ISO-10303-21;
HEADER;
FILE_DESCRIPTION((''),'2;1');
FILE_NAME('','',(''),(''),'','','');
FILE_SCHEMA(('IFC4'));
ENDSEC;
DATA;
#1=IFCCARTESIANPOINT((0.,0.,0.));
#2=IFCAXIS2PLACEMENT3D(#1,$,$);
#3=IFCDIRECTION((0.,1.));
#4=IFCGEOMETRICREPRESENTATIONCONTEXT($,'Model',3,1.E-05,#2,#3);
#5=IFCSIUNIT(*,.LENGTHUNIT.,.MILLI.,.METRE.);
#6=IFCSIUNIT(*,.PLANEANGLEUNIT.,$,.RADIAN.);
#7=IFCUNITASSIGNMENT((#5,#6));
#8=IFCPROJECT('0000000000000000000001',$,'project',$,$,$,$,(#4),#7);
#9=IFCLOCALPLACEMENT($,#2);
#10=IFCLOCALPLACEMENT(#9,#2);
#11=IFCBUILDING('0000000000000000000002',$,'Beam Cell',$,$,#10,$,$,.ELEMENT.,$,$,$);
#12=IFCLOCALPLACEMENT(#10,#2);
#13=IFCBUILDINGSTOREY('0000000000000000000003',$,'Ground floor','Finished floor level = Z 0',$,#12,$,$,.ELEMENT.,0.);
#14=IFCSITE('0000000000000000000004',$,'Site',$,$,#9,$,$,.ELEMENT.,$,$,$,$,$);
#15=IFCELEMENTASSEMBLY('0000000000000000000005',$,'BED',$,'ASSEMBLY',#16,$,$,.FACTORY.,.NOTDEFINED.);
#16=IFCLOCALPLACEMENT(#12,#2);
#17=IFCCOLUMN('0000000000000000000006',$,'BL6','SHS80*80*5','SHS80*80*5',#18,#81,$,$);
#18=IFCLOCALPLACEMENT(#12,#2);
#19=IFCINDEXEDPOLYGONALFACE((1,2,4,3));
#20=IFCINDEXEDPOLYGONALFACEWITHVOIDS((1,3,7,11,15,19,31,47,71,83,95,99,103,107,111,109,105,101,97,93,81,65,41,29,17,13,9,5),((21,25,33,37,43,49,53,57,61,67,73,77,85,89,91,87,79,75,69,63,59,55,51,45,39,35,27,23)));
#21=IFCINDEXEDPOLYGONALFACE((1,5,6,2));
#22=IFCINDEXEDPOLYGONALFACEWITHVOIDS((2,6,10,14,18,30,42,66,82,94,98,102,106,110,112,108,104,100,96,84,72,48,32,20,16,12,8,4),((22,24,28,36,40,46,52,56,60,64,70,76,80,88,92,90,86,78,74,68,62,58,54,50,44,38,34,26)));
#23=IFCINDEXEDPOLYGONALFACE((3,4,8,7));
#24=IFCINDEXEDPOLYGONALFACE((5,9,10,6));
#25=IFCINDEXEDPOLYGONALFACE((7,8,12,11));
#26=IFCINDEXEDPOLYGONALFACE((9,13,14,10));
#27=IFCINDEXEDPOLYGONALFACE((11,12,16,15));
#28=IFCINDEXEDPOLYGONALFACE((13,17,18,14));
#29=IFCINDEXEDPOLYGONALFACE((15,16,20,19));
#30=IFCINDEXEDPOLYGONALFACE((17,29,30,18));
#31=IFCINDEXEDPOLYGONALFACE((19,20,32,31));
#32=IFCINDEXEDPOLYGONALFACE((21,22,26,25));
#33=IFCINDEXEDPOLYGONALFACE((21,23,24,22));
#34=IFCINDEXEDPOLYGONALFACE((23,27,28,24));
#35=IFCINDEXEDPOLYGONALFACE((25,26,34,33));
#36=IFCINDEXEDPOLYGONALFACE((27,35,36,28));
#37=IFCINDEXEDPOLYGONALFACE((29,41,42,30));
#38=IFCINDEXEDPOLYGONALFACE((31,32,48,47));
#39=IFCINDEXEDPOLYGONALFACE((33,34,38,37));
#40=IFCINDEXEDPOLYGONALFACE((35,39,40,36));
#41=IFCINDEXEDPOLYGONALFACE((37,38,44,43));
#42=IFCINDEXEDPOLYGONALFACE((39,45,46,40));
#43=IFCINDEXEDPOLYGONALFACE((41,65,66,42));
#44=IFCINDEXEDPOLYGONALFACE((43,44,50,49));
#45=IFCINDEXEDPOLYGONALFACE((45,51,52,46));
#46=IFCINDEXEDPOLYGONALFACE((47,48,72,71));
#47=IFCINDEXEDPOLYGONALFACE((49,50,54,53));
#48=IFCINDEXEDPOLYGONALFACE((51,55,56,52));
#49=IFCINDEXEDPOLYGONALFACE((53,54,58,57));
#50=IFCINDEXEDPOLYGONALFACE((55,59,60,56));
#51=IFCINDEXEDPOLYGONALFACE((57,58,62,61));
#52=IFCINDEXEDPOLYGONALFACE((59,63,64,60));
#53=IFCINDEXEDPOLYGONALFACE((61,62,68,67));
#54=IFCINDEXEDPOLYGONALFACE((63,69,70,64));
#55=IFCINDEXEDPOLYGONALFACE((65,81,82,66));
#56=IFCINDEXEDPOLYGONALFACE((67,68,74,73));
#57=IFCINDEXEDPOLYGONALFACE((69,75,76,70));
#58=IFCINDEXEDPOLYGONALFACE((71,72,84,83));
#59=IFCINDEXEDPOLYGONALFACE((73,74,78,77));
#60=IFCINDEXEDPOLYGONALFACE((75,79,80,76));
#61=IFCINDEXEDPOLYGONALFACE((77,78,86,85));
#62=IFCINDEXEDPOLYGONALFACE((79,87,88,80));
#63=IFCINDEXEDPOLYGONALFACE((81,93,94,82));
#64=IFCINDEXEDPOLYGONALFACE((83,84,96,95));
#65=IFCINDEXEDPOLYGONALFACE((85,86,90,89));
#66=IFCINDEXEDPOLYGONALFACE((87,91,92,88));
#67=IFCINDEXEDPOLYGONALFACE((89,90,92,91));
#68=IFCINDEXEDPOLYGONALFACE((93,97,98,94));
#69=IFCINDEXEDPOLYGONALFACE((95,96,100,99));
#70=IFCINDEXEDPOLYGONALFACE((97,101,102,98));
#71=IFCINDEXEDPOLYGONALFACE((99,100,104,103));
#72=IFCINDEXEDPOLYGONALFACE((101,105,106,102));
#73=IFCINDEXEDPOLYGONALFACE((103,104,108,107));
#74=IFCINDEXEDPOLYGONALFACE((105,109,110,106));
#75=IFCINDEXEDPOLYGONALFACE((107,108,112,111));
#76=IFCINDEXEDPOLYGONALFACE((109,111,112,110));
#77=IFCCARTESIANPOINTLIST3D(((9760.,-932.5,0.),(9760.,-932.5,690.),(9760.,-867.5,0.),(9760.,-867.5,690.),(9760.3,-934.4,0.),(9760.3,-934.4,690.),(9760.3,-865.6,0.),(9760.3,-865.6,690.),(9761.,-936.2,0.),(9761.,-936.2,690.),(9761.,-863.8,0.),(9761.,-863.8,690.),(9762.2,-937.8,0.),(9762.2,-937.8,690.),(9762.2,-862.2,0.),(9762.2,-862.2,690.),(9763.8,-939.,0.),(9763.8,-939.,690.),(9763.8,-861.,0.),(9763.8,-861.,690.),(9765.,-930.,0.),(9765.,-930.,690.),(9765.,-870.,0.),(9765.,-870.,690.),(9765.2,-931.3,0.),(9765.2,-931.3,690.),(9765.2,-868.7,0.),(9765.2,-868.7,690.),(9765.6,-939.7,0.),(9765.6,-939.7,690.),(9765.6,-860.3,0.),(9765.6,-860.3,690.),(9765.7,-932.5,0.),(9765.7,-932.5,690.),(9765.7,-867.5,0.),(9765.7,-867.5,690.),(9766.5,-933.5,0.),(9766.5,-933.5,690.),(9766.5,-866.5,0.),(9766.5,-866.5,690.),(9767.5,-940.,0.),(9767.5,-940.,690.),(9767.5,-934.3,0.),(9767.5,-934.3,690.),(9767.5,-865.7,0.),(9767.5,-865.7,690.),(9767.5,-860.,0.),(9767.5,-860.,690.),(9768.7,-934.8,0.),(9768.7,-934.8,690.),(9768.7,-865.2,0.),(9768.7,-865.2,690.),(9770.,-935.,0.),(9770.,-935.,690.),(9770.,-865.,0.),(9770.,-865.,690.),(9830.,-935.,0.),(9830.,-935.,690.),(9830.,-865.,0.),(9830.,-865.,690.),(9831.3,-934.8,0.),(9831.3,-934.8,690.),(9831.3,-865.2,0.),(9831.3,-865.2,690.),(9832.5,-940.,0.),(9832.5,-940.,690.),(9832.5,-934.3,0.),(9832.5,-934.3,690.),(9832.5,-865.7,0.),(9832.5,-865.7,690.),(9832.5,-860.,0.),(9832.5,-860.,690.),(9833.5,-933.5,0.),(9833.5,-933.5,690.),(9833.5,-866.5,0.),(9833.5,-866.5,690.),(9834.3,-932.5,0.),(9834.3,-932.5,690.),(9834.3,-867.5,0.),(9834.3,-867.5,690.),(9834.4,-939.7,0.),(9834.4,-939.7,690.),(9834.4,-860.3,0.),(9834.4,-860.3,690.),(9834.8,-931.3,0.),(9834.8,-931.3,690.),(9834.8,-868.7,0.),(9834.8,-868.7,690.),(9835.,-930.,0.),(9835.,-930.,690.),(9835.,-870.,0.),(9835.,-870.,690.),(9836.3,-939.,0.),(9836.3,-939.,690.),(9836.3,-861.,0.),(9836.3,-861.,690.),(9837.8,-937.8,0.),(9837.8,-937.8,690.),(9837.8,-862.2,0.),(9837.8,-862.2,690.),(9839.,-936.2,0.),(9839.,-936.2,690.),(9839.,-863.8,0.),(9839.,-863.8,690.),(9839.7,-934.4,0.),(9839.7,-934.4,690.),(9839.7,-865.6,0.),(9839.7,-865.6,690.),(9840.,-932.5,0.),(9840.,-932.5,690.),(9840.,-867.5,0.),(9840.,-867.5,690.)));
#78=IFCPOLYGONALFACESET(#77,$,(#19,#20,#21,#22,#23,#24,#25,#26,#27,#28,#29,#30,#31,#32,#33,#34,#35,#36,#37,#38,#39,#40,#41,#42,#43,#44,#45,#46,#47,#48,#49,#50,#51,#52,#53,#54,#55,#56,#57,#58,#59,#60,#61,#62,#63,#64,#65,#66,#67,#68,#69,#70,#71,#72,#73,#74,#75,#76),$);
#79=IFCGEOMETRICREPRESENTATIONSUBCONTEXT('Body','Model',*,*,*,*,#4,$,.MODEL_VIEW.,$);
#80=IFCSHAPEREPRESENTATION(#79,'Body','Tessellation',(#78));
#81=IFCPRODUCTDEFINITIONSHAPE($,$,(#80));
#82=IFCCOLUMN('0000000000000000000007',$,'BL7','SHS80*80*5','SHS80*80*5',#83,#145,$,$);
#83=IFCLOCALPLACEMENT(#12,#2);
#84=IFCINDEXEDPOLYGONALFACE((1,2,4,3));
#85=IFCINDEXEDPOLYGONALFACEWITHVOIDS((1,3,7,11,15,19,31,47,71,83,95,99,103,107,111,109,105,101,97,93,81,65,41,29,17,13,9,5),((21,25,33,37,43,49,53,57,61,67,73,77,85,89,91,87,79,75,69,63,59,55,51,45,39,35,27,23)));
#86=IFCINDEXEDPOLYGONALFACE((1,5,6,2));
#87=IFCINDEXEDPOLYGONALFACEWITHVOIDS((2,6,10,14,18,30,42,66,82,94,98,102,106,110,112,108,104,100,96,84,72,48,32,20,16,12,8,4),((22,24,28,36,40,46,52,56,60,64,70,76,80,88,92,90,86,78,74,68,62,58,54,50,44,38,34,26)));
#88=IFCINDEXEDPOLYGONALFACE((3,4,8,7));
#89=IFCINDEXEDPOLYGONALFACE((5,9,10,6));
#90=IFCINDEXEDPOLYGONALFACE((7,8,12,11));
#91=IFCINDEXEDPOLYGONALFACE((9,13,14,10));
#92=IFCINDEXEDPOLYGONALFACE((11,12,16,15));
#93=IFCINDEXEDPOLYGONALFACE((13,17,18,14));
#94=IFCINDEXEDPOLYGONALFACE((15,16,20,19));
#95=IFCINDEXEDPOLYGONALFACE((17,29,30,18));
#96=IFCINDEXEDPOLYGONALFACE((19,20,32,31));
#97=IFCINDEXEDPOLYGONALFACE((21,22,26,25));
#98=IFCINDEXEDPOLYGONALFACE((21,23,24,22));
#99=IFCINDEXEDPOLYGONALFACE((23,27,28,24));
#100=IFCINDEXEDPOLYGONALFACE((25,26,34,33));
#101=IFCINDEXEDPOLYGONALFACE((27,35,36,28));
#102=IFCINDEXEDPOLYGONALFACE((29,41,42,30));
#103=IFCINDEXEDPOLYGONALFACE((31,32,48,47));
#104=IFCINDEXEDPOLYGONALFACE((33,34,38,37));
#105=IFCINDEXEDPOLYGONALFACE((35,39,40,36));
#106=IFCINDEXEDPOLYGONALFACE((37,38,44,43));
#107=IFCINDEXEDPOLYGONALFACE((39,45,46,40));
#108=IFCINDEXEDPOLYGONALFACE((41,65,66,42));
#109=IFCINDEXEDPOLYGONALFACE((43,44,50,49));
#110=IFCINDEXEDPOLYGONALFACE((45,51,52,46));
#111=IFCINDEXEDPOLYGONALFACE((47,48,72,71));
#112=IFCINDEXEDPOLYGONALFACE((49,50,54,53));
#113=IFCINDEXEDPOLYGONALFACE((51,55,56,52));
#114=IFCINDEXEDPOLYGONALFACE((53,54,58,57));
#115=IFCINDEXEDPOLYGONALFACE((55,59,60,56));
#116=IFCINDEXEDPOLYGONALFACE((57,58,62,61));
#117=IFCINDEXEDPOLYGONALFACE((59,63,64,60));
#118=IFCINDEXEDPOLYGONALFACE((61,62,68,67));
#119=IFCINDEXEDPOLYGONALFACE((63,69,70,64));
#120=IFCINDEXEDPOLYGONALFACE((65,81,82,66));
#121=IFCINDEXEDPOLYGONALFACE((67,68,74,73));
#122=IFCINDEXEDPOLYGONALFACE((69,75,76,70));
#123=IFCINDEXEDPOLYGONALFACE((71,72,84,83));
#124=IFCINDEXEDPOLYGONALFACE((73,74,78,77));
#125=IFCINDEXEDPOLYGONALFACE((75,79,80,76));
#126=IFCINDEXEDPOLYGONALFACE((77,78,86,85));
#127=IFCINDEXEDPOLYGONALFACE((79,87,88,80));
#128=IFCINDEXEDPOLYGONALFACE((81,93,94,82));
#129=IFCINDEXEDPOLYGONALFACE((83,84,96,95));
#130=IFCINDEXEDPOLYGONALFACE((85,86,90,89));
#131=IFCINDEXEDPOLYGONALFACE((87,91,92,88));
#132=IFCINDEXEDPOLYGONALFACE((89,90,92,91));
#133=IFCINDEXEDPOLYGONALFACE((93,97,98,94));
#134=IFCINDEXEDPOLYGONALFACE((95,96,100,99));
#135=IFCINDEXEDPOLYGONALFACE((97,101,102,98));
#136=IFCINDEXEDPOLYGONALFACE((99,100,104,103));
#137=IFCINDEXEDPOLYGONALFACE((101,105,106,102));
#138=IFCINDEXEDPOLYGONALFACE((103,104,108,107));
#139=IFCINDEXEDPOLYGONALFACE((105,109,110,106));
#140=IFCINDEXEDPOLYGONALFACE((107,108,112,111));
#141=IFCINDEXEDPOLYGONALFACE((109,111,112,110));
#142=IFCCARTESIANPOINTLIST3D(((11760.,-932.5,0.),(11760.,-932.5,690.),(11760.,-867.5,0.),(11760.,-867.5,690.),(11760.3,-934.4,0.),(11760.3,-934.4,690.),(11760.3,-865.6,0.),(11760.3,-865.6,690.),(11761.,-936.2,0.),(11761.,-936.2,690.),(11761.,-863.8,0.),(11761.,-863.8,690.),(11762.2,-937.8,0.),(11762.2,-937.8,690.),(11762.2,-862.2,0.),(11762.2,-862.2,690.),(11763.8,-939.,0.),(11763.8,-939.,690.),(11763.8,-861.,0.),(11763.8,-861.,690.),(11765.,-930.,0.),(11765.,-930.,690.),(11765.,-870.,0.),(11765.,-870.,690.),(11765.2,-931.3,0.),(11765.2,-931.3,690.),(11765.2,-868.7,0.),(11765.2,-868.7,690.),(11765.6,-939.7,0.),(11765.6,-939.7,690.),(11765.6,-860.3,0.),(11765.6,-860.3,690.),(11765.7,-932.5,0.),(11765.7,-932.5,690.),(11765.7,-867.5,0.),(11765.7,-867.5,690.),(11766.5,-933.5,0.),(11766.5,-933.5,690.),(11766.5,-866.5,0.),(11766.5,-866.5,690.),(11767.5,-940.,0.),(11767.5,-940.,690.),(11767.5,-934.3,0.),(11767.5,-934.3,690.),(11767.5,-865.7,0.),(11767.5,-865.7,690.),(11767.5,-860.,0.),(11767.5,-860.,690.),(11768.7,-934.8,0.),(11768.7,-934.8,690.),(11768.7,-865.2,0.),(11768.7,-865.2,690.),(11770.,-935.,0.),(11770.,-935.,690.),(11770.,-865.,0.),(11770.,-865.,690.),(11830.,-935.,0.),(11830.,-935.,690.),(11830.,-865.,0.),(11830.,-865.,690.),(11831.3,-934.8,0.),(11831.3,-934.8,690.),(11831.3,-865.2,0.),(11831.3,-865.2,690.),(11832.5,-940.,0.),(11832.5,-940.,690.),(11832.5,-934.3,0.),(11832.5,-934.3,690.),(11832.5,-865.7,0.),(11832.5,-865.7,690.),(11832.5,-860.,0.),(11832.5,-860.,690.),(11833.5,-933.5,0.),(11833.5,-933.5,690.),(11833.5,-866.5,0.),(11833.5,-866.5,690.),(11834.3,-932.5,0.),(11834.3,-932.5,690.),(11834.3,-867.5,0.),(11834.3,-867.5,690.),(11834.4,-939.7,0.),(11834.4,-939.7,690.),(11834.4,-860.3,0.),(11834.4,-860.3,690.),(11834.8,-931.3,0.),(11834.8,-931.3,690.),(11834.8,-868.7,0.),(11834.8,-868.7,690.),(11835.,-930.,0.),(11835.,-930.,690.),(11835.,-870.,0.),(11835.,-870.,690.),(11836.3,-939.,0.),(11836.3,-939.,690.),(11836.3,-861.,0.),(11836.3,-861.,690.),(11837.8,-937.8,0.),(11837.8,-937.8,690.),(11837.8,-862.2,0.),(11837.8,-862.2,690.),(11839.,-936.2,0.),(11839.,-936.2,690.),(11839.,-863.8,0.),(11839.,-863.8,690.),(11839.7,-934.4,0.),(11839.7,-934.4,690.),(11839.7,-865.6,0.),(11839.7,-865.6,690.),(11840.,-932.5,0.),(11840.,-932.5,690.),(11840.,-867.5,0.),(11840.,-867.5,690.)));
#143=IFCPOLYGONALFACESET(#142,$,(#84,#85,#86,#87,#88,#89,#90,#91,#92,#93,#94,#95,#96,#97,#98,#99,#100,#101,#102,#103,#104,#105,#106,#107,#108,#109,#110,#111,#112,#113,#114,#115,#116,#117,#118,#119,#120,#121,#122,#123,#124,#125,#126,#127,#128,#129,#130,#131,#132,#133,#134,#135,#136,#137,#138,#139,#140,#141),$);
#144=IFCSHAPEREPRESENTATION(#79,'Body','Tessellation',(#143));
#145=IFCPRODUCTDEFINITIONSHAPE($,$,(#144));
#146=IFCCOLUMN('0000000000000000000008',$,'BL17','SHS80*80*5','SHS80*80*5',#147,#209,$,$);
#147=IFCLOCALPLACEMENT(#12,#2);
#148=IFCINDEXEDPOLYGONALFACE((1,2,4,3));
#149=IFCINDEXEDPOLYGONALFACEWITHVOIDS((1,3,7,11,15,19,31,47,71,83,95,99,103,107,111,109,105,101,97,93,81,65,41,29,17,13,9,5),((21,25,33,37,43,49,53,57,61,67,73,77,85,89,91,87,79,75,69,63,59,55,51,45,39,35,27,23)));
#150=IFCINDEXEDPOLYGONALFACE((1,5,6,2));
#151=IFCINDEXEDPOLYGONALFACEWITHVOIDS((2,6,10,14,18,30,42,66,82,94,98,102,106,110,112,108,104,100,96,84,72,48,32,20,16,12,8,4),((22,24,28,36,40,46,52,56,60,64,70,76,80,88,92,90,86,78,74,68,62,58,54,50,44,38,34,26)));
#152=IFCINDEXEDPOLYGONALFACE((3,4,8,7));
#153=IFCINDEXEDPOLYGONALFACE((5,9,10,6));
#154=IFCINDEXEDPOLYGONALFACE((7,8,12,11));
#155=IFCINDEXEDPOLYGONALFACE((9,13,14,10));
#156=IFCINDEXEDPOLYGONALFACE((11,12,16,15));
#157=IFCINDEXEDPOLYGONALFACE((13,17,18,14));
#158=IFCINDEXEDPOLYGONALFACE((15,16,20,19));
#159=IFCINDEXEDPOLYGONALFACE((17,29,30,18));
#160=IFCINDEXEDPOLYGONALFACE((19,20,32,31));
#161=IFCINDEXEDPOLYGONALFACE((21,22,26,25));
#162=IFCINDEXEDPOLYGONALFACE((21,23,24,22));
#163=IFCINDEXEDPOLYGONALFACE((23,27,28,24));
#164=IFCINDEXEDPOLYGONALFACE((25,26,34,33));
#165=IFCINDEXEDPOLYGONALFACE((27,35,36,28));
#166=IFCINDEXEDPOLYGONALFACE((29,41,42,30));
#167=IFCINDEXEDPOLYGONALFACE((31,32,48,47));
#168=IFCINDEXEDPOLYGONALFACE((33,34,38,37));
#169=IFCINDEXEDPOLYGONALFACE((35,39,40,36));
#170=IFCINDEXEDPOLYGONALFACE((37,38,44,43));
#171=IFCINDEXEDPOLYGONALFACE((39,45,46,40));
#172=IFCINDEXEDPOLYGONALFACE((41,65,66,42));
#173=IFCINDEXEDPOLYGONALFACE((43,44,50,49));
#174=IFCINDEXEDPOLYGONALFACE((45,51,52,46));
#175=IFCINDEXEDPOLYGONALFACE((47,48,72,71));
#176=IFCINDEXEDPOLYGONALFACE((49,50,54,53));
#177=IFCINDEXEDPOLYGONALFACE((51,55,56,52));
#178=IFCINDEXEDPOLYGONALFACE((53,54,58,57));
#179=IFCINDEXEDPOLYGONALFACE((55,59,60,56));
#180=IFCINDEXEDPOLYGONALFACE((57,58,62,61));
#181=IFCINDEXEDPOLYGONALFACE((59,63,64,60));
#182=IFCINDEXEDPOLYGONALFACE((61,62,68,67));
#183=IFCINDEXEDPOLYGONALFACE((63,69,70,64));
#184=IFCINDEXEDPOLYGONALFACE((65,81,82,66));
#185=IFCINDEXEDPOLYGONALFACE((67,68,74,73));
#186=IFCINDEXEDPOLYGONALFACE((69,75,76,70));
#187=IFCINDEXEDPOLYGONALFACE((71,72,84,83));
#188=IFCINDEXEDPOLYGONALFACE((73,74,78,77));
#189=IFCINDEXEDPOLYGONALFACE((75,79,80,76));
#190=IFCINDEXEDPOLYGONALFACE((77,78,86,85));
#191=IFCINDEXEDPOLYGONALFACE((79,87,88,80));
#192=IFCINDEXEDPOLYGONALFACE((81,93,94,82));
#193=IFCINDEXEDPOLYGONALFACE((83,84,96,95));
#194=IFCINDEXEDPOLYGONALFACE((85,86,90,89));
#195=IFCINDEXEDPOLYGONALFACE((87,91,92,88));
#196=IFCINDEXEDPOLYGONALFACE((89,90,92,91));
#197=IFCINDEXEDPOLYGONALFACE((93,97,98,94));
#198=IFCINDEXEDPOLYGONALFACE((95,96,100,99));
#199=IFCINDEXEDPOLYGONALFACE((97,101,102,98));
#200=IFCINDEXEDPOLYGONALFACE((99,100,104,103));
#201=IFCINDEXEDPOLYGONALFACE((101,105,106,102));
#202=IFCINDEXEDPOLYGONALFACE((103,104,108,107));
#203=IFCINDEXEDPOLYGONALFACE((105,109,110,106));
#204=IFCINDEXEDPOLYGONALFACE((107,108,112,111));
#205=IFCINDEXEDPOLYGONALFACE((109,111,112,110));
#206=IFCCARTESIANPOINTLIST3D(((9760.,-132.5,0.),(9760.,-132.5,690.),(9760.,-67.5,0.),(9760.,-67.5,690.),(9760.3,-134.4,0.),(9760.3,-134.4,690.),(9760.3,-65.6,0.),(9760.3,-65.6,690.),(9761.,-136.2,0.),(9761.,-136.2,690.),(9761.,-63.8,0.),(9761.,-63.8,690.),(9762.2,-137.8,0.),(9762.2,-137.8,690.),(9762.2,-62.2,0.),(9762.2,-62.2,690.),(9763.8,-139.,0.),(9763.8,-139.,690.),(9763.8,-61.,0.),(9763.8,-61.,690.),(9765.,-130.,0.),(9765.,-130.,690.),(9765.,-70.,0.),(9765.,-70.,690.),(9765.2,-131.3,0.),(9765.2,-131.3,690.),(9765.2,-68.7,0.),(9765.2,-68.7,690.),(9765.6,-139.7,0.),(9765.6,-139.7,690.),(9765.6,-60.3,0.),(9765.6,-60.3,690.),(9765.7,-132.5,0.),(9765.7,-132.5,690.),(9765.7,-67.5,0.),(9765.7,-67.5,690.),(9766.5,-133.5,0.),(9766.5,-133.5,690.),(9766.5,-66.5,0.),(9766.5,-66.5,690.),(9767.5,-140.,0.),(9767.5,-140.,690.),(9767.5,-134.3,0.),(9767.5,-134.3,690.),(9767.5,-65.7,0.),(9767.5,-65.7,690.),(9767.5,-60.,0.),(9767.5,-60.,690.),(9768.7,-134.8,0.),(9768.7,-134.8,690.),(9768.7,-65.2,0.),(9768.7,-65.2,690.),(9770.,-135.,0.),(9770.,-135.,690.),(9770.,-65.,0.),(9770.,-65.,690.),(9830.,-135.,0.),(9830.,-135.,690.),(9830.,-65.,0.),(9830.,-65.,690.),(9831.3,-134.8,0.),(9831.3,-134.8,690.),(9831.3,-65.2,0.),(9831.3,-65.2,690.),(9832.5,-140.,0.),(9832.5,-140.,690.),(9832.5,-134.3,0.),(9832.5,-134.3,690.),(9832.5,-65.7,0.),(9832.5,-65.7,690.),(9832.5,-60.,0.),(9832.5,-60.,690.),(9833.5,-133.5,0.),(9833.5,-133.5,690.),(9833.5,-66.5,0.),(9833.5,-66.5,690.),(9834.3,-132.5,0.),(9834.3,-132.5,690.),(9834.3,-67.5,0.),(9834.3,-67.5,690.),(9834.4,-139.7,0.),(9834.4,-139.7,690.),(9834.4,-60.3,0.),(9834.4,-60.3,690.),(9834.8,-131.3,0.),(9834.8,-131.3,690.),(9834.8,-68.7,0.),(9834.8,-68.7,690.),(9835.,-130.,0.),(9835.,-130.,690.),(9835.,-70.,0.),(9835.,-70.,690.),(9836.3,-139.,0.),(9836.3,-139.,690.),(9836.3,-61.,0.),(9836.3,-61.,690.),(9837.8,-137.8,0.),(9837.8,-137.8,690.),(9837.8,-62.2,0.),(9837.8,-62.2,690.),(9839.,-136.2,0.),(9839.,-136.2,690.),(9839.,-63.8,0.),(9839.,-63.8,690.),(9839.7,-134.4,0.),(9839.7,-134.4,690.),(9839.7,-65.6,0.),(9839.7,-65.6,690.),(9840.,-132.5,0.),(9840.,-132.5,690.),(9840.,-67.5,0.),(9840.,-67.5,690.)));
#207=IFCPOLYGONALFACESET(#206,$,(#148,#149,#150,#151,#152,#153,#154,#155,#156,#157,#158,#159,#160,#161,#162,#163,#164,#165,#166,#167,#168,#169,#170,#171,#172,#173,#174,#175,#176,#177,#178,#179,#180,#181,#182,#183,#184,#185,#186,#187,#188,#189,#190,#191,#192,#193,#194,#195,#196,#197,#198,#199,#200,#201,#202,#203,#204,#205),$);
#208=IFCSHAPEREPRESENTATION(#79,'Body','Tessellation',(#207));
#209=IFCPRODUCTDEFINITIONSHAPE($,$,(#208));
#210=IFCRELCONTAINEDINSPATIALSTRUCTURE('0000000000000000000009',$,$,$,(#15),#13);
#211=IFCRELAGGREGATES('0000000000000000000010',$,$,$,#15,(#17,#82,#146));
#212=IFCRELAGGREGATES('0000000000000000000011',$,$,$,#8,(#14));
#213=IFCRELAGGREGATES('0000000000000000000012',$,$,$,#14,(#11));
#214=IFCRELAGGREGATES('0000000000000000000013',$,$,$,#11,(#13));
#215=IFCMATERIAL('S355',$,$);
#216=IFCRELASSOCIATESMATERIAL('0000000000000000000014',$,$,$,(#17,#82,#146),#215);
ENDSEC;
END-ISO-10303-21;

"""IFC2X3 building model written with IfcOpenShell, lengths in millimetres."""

from ifc_helpers import new_model, si_unit, direction, frame, origin, origin_2d, place, context, subcontext, project, spatial, hollow_rectangle, extrude, material, element, aggregate, save


model = new_model("IFC2X3")

# Units and contexts
model_context = context("Model", 3, precision=1e-05, world=origin(), true_north=direction((0.0, 1.0)))
body_context = subcontext(model_context, "Body", "Model", "MODEL_VIEW")
ifc_project = project(units=[si_unit("LENGTHUNIT", "METRE", prefix="MILLI"), si_unit("PLANEANGLEUNIT", "RADIAN")], contexts=[model_context])

# Site, building, storey
site_placement = place(None, origin())
site = spatial("IfcSite", under=ifc_project, at=site_placement, Name="Site", CompositionType="ELEMENT")
building_placement = place(site_placement, origin())
building = spatial("IfcBuilding", under=site, at=building_placement, Name="Beam Cell", CompositionType="ELEMENT")
storey_placement = place(building_placement, origin())
storey = spatial("IfcBuildingStorey", under=building, at=storey_placement, Name="Ground floor", Description="Finished floor level = Z 0", CompositionType="ELEMENT", Elevation=0.0)

# Element assembly, columns
ifc_material = material(Name="S355")
assembly_1_placement = place(storey_placement, origin())
assembly_1 = element("IfcElementAssembly", 1, at=assembly_1_placement, inside=storey, Name="BED", ObjectType="ASSEMBLY", AssemblyPlace="FACTORY", PredefinedType="NOTDEFINED")
column_1_placement = place(storey_placement, frame((9800.0, -900.0, 0.0), z_axis=(0.0, 0.0, 1.0), x_axis=(1.0, 0.0, 0.0)))
column_1 = element("IfcColumn", 2, at=column_1_placement, material=ifc_material, Name="BL6", Description="SHS80*80*5", ObjectType="SHS80*80*5", context=body_context, shape_type="SweptSolid", body=[
    extrude(hollow_rectangle(XDim=80.0, YDim=80.0, WallThickness=5.0, InnerFilletRadius=5.0, OuterFilletRadius=7.5, at=origin_2d()), origin(), (0.0, 0.0, 1.0), 690.0),
])
column_2_placement = place(storey_placement, frame((11800.0, -900.0, 0.0), z_axis=(0.0, 0.0, 1.0), x_axis=(1.0, 0.0, 0.0)))
column_2 = element("IfcColumn", 3, at=column_2_placement, material=ifc_material, Name="BL7", Description="SHS80*80*5", ObjectType="SHS80*80*5", context=body_context, shape_type="SweptSolid", body=[
    extrude(hollow_rectangle(XDim=80.0, YDim=80.0, WallThickness=5.0, InnerFilletRadius=5.0, OuterFilletRadius=7.5, at=origin_2d()), origin(), (0.0, 0.0, 1.0), 690.0),
])
column_3_placement = place(storey_placement, frame((9800.0, -100.0, 0.0), z_axis=(0.0, 0.0, 1.0), x_axis=(1.0, 0.0, 0.0)))
column_3 = element("IfcColumn", 4, at=column_3_placement, material=ifc_material, Name="BL17", Description="SHS80*80*5", ObjectType="SHS80*80*5", context=body_context, shape_type="SweptSolid", body=[
    extrude(hollow_rectangle(XDim=80.0, YDim=80.0, WallThickness=5.0, InnerFilletRadius=5.0, OuterFilletRadius=7.5, at=origin_2d()), origin(), (0.0, 0.0, 1.0), 690.0),
])

aggregate(assembly_1, [column_1, column_2, column_3])

save(model, "model.ifc")
